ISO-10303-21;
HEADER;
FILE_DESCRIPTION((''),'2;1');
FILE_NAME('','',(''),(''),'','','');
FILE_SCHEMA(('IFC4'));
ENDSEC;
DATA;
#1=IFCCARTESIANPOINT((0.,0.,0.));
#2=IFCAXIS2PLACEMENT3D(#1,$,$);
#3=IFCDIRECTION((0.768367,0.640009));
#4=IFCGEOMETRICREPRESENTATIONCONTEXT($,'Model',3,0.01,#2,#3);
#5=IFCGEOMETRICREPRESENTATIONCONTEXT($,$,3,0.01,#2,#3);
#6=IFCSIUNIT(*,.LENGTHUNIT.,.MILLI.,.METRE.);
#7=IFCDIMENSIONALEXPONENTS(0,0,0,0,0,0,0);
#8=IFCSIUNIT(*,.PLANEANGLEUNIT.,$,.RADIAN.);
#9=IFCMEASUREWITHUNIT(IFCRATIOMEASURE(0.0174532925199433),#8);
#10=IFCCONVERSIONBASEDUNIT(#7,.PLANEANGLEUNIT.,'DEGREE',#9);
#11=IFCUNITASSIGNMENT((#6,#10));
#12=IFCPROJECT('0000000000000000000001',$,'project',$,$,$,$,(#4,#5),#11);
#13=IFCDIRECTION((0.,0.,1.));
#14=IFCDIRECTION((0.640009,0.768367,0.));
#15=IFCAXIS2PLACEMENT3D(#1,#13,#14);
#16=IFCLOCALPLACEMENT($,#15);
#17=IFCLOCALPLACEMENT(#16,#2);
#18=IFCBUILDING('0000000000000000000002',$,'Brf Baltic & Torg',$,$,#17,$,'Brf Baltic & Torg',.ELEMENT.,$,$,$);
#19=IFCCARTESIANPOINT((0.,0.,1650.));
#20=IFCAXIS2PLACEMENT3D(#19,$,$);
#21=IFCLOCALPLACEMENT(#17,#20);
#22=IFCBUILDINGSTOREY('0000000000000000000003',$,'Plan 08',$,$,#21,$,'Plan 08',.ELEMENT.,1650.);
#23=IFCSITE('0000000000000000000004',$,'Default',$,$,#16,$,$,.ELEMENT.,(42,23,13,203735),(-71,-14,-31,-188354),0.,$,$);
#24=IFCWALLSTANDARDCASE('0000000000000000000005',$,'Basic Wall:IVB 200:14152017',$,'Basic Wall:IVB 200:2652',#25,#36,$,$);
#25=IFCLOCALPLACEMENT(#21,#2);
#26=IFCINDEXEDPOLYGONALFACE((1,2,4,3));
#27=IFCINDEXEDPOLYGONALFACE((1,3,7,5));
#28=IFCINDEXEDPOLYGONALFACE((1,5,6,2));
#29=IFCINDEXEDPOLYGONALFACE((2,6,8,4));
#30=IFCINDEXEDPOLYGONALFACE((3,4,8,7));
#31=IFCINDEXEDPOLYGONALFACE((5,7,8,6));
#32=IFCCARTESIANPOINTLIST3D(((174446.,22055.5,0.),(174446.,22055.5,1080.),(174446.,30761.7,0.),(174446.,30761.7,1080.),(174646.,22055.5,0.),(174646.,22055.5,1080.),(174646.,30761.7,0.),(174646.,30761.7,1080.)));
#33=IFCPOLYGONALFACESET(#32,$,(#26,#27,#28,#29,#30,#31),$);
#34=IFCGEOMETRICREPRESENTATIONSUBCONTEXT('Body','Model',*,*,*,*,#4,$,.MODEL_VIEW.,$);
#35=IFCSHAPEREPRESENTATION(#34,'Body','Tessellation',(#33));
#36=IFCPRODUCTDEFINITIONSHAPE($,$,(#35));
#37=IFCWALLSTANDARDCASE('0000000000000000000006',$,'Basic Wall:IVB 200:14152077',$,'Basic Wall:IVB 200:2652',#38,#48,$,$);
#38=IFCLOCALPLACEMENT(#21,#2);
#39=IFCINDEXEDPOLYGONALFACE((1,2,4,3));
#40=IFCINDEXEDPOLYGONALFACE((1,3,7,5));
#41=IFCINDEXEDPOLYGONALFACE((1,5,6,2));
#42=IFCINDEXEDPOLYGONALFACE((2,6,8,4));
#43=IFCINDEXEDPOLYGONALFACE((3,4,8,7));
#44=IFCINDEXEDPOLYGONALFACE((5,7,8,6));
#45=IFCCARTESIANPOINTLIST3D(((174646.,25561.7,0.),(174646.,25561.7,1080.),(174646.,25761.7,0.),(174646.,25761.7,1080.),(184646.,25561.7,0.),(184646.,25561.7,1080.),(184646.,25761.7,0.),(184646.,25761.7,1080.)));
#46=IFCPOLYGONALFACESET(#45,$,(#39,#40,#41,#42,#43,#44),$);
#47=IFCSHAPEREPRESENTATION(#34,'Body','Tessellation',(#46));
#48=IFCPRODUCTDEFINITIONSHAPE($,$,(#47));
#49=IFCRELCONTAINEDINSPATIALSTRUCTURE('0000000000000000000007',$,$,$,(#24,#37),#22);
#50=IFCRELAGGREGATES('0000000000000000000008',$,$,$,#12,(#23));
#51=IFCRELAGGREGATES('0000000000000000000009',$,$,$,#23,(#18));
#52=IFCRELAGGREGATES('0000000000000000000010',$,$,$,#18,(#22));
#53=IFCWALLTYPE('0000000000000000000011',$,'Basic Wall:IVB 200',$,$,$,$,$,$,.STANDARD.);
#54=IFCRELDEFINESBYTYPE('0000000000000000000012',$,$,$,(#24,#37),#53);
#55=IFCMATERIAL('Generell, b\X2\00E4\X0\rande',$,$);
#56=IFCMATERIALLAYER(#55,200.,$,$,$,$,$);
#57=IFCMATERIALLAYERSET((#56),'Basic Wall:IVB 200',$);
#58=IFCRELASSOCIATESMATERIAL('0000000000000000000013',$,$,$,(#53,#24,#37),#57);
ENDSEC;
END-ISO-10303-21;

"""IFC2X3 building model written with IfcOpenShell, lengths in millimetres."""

from ifc_helpers import new_model, entity, si_unit, converted_unit, direction, frame, frame_2d, origin, place, context, subcontext, project, spatial, rectangle, extrude, clip, halfspace, material, layer, layer_set, layer_usage, type_object, element, save


model = new_model("IFC2X3")

# Units and contexts
model_context = context("Model", 3, precision=0.01, world=origin(), true_north=direction((0.768367, 0.640009)))
context_of_model = context(None, 3, precision=0.01, world=origin(), true_north=direction((0.768367, 0.640009)))
body_context = subcontext(model_context, "Body", "Model", "MODEL_VIEW")
ifc_project = project(units=[si_unit("LENGTHUNIT", "METRE", prefix="MILLI"), converted_unit("PLANEANGLEUNIT", "DEGREE", entity("IfcRatioMeasure", 0.0174532925199433), si_unit("PLANEANGLEUNIT", "RADIAN"), dimensions=[0, 0, 0, 0, 0, 0, 0])], contexts=[model_context, context_of_model])

# Site, building, storey
site_placement = place(None, frame((0.0, 0.0, 0.0), z_axis=(0.0, 0.0, 1.0), x_axis=(0.640009, 0.768367, 0.0)))
site = spatial("IfcSite", under=ifc_project, at=site_placement, Name="Default", CompositionType="ELEMENT", RefLatitude=(42, 23, 13, 203735), RefLongitude=(-71, -14, -31, -188354), RefElevation=0.0)
building_placement = place(site_placement, origin())
building = spatial("IfcBuilding", under=site, at=building_placement, Name="Brf Baltic & Torg", LongName="Brf Baltic & Torg", CompositionType="ELEMENT")
storey_placement = place(building_placement, frame((0.0, 0.0, 1650.0)))
storey = spatial("IfcBuildingStorey", under=building, at=storey_placement, Name="Plan 08", LongName="Plan 08", CompositionType="ELEMENT", Elevation=1650.0)

# Shared definitions
ifc_material_1 = material(Name="Generell, bärande")
ifc_layer = layer(ifc_material_1, 200.0)
ifc_layer_set = layer_set([ifc_layer], Name="Basic Wall:IVB 200")
wall_type = type_object("IfcWallType", Name="Basic Wall:IVB 200", PredefinedType="STANDARD", material=ifc_layer_set)

# Walls
ifc_layer_usage_1 = layer_usage(ifc_layer_set, "AXIS2", "POSITIVE", -100.0)
wall_1_placement = place(storey_placement, frame((174546.0, 30761.7, 0.0), z_axis=(0.0, 0.0, 1.0), x_axis=(0.0, -1.0, 0.0)))
element("IfcWallStandardCase", 1, at=wall_1_placement, inside=storey, type_object=wall_type, material=ifc_layer_usage_1, Name="Basic Wall:IVB 200:14152017", ObjectType="Basic Wall:IVB 200:2652", context=body_context, shape_type="Clipping", body=[
    clip(extrude(rectangle(XDim=8706.2, YDim=200.0, at=frame_2d((4353.1, 0.0), x_axis=(-1.0, 0.0))), origin(), (0.0, 0.0, 1.0), 1080.0), halfspace(origin(), True)),
])
ifc_layer_usage_2 = layer_usage(ifc_layer_set, "AXIS2", "NEGATIVE", 100.0)
wall_2_placement = place(storey_placement, frame((174646.0, 25661.7, 0.0)))
element("IfcWallStandardCase", 2, at=wall_2_placement, inside=storey, type_object=wall_type, material=ifc_layer_usage_2, Name="Basic Wall:IVB 200:14152077", ObjectType="Basic Wall:IVB 200:2652", context=body_context, shape_type="Clipping", body=[
    clip(extrude(rectangle(XDim=10000.0, YDim=200.0, at=frame_2d((5000.0, 0.0), x_axis=(-1.0, 0.0))), origin(), (0.0, 0.0, 1.0), 1080.0), halfspace(origin(), True)),
])

save(model, "model.ifc")
